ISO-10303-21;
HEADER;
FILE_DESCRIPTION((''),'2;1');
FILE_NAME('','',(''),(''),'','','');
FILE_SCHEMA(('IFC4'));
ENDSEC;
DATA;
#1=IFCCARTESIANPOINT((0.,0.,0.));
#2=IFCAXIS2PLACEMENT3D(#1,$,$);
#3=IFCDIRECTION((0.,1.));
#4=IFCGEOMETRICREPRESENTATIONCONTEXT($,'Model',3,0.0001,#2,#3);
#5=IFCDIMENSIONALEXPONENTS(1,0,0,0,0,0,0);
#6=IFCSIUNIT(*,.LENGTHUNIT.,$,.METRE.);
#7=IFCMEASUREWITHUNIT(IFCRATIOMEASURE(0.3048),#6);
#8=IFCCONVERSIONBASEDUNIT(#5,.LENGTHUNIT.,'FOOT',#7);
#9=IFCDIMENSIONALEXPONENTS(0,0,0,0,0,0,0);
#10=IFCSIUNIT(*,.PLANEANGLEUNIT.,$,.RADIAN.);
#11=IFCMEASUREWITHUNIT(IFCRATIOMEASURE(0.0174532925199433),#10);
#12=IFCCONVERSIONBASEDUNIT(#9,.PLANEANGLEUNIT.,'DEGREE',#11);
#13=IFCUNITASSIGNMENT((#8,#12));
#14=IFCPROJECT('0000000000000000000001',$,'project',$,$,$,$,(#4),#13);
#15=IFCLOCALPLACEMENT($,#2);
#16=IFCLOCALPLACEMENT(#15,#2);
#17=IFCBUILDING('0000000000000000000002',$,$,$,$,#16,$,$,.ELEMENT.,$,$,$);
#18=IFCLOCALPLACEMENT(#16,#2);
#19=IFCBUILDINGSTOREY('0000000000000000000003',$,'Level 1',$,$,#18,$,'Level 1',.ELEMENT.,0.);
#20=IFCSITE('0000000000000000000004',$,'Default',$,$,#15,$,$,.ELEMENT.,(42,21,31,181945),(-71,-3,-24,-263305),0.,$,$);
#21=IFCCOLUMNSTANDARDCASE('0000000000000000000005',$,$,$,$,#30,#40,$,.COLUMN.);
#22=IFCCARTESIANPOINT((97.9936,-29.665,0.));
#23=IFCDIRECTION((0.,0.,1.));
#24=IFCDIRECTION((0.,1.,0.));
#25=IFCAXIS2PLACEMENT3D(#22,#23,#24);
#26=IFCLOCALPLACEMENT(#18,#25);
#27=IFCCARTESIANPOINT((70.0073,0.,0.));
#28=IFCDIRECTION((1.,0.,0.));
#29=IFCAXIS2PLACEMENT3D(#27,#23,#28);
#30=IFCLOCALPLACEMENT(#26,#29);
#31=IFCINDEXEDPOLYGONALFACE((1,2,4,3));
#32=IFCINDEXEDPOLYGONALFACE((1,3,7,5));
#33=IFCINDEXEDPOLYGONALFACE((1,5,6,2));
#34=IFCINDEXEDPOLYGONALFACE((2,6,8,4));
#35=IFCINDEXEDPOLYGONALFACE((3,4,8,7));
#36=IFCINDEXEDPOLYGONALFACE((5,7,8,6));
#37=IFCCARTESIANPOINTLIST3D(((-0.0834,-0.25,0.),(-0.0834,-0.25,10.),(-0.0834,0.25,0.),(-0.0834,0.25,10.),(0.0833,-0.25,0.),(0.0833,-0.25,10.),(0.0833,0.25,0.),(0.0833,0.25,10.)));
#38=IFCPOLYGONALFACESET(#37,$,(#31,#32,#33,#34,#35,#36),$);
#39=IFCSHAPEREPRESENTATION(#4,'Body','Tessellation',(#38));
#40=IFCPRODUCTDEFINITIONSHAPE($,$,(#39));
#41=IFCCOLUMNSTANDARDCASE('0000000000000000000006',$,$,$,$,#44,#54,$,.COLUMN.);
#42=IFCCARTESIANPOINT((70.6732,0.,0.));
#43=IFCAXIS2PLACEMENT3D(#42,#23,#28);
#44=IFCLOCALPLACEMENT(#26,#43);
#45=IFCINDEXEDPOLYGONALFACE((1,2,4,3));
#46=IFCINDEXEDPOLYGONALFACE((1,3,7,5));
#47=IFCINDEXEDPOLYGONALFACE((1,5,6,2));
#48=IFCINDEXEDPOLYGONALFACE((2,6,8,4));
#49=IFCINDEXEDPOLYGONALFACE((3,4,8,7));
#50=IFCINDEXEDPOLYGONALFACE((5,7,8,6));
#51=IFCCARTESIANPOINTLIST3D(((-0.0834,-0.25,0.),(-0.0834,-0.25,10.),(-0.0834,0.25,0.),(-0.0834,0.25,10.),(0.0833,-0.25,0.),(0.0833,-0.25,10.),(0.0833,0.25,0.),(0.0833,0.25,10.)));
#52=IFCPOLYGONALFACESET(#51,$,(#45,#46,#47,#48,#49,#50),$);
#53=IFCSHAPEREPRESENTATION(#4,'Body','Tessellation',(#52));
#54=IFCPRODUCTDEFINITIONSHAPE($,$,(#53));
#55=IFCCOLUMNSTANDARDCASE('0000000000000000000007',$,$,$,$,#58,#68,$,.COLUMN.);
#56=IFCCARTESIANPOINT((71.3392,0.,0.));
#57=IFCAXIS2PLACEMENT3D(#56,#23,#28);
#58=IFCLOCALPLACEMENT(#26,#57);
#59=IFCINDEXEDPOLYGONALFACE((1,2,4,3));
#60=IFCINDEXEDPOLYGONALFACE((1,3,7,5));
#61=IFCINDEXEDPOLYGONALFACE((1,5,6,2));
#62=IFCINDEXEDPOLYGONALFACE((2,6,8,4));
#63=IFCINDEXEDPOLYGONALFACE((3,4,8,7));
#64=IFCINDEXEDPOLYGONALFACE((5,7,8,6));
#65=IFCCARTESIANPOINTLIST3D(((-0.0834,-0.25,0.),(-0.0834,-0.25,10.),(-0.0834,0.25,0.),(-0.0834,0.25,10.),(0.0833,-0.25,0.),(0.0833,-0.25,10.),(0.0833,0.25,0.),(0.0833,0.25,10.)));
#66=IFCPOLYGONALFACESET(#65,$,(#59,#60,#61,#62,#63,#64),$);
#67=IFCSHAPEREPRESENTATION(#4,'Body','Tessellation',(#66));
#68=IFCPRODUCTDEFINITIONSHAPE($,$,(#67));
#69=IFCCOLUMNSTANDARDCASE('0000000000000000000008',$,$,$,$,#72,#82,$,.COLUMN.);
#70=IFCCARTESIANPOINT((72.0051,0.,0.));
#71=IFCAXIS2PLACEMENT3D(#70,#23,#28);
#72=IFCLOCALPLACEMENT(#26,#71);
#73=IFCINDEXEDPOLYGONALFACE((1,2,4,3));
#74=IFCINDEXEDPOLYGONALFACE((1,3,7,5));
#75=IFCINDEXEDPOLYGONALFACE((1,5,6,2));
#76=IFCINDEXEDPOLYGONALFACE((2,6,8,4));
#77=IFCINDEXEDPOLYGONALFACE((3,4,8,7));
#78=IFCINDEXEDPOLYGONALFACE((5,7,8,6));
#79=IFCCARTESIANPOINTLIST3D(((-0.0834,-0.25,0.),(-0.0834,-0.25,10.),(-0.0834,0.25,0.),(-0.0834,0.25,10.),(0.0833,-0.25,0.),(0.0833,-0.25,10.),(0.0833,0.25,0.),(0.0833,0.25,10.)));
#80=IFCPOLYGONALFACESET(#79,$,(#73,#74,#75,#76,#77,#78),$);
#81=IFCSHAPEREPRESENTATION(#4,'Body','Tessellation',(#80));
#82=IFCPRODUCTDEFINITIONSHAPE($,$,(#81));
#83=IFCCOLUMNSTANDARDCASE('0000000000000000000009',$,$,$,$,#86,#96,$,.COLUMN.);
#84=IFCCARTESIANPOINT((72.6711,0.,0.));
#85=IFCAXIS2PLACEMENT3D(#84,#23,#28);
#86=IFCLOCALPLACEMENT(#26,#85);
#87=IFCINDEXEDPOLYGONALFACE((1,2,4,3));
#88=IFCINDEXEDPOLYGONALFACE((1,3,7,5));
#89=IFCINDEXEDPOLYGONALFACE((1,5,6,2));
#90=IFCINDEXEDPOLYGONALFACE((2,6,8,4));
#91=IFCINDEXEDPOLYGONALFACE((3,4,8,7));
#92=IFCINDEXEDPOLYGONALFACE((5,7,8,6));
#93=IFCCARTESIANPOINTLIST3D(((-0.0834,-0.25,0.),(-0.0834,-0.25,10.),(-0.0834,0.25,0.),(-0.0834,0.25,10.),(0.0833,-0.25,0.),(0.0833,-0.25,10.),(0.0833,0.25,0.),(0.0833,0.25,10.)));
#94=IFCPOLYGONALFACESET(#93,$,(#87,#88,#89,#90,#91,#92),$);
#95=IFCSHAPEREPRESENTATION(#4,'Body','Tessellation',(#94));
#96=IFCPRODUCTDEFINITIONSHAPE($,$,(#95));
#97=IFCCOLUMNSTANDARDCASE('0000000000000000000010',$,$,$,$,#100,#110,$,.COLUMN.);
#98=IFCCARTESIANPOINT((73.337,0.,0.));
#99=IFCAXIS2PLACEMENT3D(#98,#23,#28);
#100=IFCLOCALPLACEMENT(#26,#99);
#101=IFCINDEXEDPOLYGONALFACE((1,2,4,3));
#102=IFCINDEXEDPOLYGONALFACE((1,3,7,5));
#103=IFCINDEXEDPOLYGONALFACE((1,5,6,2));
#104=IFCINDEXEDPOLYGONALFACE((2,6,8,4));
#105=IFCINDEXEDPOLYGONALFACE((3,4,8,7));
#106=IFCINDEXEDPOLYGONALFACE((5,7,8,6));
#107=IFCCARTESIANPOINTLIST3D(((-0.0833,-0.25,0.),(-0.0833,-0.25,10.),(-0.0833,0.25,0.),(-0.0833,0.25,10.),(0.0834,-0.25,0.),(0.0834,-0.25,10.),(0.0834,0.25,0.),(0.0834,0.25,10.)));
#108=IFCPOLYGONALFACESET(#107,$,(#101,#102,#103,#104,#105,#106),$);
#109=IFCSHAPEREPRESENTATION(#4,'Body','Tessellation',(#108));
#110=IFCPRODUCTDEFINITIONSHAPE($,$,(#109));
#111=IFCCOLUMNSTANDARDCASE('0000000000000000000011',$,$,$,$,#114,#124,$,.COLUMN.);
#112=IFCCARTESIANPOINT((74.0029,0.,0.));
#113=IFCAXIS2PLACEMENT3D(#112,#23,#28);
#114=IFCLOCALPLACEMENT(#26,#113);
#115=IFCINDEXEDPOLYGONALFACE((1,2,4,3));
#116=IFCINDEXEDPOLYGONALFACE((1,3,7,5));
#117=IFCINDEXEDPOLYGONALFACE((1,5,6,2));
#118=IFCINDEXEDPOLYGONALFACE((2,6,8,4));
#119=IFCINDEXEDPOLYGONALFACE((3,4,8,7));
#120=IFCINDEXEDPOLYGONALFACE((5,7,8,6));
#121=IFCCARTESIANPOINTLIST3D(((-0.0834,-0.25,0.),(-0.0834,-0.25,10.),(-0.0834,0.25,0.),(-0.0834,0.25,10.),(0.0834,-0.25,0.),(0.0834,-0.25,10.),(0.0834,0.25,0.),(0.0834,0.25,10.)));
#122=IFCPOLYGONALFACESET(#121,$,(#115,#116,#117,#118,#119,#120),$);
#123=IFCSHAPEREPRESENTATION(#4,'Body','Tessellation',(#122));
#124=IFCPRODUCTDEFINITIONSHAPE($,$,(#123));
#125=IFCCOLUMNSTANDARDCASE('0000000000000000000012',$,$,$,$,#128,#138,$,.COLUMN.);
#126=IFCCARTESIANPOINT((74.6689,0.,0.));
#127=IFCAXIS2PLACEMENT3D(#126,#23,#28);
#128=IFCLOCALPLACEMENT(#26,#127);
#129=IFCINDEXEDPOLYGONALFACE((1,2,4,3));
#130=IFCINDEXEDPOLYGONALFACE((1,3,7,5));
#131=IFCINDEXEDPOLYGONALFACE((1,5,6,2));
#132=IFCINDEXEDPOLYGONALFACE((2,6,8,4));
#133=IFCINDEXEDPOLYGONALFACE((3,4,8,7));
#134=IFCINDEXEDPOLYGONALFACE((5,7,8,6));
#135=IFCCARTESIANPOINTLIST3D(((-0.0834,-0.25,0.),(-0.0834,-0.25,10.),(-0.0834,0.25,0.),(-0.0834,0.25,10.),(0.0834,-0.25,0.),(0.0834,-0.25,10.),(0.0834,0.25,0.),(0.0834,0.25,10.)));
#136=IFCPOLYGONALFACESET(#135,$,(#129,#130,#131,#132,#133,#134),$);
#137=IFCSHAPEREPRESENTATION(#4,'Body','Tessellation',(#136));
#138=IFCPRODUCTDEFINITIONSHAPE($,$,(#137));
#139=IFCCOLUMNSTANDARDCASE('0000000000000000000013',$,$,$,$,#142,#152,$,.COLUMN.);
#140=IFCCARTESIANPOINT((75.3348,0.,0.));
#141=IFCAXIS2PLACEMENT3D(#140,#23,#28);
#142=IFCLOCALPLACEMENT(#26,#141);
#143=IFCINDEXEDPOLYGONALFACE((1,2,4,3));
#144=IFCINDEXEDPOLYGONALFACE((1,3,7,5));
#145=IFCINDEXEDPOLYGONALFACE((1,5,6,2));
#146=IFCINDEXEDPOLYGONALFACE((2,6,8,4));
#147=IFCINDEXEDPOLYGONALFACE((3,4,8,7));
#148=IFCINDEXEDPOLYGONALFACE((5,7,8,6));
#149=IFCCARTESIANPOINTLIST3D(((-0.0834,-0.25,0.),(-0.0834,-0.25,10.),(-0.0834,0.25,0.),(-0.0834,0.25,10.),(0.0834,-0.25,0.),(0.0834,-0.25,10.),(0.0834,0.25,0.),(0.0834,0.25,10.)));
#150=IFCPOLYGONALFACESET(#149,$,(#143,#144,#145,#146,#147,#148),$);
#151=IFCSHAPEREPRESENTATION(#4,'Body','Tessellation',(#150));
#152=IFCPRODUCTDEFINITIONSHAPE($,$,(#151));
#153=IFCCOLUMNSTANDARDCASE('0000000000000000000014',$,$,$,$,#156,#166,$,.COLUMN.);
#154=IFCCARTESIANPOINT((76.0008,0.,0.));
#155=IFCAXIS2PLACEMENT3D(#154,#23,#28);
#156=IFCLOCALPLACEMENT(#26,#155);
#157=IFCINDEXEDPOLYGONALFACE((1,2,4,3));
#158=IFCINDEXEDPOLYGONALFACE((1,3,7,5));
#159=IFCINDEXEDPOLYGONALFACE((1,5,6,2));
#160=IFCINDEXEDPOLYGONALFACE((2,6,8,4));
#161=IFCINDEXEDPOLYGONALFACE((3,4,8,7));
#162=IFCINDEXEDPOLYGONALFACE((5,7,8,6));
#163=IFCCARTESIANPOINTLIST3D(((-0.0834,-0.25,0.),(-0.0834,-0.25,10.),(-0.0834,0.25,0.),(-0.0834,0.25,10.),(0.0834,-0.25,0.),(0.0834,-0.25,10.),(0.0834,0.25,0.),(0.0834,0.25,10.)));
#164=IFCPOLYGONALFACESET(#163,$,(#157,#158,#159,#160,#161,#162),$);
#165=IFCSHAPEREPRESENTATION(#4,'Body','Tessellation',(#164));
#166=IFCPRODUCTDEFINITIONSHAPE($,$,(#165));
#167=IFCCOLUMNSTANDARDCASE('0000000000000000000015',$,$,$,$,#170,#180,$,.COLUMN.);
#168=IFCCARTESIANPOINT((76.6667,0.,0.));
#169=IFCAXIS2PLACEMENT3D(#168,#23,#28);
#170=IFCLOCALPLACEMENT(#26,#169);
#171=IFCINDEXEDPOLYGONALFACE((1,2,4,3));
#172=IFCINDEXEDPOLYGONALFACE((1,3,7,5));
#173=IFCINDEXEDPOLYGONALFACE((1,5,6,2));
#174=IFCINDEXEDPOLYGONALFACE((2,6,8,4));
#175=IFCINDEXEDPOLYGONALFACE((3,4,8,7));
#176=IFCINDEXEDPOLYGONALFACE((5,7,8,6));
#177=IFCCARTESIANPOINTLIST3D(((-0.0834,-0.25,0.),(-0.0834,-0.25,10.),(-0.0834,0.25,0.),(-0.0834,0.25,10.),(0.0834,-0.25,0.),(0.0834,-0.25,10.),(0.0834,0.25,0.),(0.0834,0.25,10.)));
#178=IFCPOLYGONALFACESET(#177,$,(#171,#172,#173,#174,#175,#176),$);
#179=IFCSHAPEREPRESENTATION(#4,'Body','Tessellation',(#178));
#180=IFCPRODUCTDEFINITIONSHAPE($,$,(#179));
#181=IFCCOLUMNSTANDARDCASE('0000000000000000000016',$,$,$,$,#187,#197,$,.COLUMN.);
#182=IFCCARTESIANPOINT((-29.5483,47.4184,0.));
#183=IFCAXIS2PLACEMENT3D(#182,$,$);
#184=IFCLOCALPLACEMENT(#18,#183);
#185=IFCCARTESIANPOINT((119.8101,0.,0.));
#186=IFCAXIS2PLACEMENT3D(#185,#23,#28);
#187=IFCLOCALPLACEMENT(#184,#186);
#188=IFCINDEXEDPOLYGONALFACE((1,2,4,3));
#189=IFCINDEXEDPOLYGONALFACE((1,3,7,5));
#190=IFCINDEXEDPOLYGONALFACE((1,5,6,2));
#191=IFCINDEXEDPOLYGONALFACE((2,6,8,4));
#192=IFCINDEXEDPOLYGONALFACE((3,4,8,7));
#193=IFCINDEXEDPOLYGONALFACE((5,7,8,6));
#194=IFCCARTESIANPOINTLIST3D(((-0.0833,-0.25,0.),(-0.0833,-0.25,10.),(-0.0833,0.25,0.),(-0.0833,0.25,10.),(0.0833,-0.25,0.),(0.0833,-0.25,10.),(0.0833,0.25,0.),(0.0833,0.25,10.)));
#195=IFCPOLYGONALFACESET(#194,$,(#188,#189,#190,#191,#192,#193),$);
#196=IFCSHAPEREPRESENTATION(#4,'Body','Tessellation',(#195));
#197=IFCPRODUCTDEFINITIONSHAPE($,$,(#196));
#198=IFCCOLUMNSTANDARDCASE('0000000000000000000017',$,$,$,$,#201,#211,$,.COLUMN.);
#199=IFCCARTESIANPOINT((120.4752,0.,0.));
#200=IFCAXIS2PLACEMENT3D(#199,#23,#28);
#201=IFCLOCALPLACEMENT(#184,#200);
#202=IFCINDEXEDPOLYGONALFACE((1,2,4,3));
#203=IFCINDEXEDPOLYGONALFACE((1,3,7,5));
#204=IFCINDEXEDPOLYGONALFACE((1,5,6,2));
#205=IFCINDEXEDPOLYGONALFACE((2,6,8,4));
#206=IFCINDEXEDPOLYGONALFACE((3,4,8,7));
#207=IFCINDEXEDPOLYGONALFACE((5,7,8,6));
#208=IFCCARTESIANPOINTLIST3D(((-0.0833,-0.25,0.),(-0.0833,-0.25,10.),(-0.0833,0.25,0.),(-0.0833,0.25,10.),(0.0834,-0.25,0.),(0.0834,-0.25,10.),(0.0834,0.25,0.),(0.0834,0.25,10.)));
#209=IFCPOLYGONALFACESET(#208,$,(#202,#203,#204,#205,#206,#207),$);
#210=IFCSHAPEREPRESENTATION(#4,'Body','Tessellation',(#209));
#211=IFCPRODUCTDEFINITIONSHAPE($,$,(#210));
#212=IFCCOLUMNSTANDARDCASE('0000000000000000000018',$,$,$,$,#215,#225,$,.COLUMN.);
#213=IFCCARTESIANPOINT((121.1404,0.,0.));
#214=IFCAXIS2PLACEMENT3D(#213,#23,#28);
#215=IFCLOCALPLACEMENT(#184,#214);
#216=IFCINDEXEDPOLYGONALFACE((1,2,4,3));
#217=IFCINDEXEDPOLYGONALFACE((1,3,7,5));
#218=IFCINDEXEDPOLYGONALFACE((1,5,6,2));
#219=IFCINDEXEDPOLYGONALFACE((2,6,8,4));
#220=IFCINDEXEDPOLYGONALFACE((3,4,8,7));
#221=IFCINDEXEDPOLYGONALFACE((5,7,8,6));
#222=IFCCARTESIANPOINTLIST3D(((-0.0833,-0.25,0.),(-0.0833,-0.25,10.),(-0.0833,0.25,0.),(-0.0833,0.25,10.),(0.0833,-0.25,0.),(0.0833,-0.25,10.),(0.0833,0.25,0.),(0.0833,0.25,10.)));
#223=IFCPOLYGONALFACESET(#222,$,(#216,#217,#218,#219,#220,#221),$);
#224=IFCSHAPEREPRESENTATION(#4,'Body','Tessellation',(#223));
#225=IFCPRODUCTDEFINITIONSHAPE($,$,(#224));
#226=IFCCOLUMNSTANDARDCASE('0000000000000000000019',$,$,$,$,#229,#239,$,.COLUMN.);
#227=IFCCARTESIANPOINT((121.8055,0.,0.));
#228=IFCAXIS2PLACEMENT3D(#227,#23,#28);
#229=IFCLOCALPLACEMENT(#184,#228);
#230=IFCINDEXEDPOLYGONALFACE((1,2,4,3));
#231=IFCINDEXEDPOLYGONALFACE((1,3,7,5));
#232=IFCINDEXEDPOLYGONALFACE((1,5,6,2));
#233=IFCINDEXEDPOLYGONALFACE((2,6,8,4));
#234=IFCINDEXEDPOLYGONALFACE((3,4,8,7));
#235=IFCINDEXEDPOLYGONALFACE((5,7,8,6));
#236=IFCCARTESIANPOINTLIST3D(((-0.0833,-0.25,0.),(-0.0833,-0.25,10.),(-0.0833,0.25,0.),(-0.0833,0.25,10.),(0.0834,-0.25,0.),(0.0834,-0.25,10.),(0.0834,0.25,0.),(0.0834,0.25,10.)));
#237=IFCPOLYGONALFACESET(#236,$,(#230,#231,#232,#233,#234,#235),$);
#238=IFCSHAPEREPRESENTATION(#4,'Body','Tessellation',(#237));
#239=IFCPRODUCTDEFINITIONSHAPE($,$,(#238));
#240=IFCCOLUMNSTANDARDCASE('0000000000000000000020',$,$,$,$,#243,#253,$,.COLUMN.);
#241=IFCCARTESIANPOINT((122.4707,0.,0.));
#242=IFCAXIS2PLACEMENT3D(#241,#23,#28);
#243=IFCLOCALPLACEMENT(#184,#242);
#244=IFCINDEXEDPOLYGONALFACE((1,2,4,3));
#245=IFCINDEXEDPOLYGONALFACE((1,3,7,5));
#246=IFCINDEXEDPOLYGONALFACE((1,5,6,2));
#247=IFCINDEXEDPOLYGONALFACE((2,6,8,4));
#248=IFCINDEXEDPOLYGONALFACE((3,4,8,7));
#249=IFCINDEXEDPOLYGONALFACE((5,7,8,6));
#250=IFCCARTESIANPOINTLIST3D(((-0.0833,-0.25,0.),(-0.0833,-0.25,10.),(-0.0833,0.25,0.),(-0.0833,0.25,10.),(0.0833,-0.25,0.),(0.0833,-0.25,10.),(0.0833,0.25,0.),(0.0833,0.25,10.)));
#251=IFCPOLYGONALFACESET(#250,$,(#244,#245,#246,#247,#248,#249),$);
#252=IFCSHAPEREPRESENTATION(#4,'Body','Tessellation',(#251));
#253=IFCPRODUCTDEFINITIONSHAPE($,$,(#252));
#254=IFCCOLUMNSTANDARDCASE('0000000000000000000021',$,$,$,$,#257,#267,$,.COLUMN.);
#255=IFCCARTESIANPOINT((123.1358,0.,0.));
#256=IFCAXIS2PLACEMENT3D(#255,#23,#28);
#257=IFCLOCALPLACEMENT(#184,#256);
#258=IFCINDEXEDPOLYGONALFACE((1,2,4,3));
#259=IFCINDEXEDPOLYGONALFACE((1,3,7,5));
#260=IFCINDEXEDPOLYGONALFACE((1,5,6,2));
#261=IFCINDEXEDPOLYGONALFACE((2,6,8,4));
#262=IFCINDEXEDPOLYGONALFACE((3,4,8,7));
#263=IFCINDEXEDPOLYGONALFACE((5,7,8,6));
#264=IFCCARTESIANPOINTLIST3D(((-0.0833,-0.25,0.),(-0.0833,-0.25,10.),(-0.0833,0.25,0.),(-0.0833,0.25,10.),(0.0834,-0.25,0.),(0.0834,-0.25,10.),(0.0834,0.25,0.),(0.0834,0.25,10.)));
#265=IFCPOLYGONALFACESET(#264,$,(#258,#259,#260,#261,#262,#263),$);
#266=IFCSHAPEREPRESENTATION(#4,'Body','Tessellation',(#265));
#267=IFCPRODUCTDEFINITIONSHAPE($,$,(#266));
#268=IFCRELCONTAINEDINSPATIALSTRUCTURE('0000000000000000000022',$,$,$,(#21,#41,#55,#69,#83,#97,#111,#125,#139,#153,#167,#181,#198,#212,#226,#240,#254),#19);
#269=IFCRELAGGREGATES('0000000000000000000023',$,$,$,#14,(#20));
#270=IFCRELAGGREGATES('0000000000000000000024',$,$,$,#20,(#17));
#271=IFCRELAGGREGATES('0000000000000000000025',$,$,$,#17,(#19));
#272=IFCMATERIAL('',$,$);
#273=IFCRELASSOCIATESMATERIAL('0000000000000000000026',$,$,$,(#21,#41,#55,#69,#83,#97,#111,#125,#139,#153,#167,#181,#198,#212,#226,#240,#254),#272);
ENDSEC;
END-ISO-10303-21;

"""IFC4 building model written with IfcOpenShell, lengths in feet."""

from ifc_helpers import new_model, entity, si_unit, converted_unit, direction, frame, origin, place, context, project, spatial, rectangle, extrude, material, element, save


model = new_model("IFC4")

# Units and contexts
model_context = context("Model", 3, precision=0.0001, world=origin(), true_north=direction((0.0, 1.0)))
ifc_project = project(units=[converted_unit("LENGTHUNIT", "FOOT", entity("IfcRatioMeasure", 0.3048), si_unit("LENGTHUNIT", "METRE"), dimensions=[1, 0, 0, 0, 0, 0, 0]), converted_unit("PLANEANGLEUNIT", "DEGREE", entity("IfcRatioMeasure", 0.0174532925199433), si_unit("PLANEANGLEUNIT", "RADIAN"), dimensions=[0, 0, 0, 0, 0, 0, 0])], contexts=[model_context])

# Site, building, storey
site_placement = place(None, origin())
site = spatial("IfcSite", under=ifc_project, at=site_placement, Name="Default", CompositionType="ELEMENT", RefLatitude=(42, 21, 31, 181945), RefLongitude=(-71, -3, -24, -263305), RefElevation=0.0)
building_placement = place(site_placement, origin())
building = spatial("IfcBuilding", under=site, at=building_placement, CompositionType="ELEMENT")
storey_placement = place(building_placement, origin())
storey = spatial("IfcBuildingStorey", under=building, at=storey_placement, Name="Level 1", LongName="Level 1", CompositionType="ELEMENT", Elevation=0.0)

# Columns
ifc_material = material(Name="")
placement_1 = place(storey_placement, frame((97.9936, -29.665, 0.0), z_axis=(0.0, 0.0, 1.0), x_axis=(0.0, 1.0, 0.0)))
for number, where, z_axis, x_axis in (
    (1, (70.0073, 0.0, 0.0), (0.0, 0.0, 1.0), (1.0, 0.0, 0.0)),
    (2, (70.6732, 0.0, 0.0), (0.0, 0.0, 1.0), (1.0, 0.0, 0.0)),
    (3, (71.3392, 0.0, 0.0), (0.0, 0.0, 1.0), (1.0, 0.0, 0.0)),
    (4, (72.0051, 0.0, 0.0), (0.0, 0.0, 1.0), (1.0, 0.0, 0.0)),
    (5, (72.6711, 0.0, 0.0), (0.0, 0.0, 1.0), (1.0, 0.0, 0.0)),
    (6, (73.337, 0.0, 0.0), (0.0, 0.0, 1.0), (1.0, 0.0, 0.0)),
    (7, (74.0029, 0.0, 0.0), (0.0, 0.0, 1.0), (1.0, 0.0, 0.0)),
    (8, (74.6689, 0.0, 0.0), (0.0, 0.0, 1.0), (1.0, 0.0, 0.0)),
    (9, (75.3348, 0.0, 0.0), (0.0, 0.0, 1.0), (1.0, 0.0, 0.0)),
    (10, (76.0008, 0.0, 0.0), (0.0, 0.0, 1.0), (1.0, 0.0, 0.0)),
    (11, (76.6667, 0.0, 0.0), (0.0, 0.0, 1.0), (1.0, 0.0, 0.0)),
):
    element("IfcColumnStandardCase", number, at=place(placement_1, frame(where, z_axis=z_axis, x_axis=x_axis)), inside=storey, material=ifc_material, PredefinedType="COLUMN", context=model_context, shape_type="SweptSolid", body=[
        extrude(rectangle(XDim=0.1667, YDim=0.5), origin(), (0.0, 0.0, 1.0), 10.0),
    ])
placement_2 = place(storey_placement, frame((-29.5483, 47.4184, 0.0)))
for number, where, z_axis, x_axis in (
    (12, (119.8101, 0.0, 0.0), (0.0, 0.0, 1.0), (1.0, 0.0, 0.0)),
    (13, (120.4752, 0.0, 0.0), (0.0, 0.0, 1.0), (1.0, 0.0, 0.0)),
    (14, (121.1404, 0.0, 0.0), (0.0, 0.0, 1.0), (1.0, 0.0, 0.0)),
    (15, (121.8055, 0.0, 0.0), (0.0, 0.0, 1.0), (1.0, 0.0, 0.0)),
    (16, (122.4707, 0.0, 0.0), (0.0, 0.0, 1.0), (1.0, 0.0, 0.0)),
    (17, (123.1358, 0.0, 0.0), (0.0, 0.0, 1.0), (1.0, 0.0, 0.0)),
):
    element("IfcColumnStandardCase", number, at=place(placement_2, frame(where, z_axis=z_axis, x_axis=x_axis)), inside=storey, material=ifc_material, PredefinedType="COLUMN", context=model_context, shape_type="SweptSolid", body=[
        extrude(rectangle(XDim=0.1667, YDim=0.5), origin(), (0.0, 0.0, 1.0), 10.0),
    ])

save(model, "model.ifc")
